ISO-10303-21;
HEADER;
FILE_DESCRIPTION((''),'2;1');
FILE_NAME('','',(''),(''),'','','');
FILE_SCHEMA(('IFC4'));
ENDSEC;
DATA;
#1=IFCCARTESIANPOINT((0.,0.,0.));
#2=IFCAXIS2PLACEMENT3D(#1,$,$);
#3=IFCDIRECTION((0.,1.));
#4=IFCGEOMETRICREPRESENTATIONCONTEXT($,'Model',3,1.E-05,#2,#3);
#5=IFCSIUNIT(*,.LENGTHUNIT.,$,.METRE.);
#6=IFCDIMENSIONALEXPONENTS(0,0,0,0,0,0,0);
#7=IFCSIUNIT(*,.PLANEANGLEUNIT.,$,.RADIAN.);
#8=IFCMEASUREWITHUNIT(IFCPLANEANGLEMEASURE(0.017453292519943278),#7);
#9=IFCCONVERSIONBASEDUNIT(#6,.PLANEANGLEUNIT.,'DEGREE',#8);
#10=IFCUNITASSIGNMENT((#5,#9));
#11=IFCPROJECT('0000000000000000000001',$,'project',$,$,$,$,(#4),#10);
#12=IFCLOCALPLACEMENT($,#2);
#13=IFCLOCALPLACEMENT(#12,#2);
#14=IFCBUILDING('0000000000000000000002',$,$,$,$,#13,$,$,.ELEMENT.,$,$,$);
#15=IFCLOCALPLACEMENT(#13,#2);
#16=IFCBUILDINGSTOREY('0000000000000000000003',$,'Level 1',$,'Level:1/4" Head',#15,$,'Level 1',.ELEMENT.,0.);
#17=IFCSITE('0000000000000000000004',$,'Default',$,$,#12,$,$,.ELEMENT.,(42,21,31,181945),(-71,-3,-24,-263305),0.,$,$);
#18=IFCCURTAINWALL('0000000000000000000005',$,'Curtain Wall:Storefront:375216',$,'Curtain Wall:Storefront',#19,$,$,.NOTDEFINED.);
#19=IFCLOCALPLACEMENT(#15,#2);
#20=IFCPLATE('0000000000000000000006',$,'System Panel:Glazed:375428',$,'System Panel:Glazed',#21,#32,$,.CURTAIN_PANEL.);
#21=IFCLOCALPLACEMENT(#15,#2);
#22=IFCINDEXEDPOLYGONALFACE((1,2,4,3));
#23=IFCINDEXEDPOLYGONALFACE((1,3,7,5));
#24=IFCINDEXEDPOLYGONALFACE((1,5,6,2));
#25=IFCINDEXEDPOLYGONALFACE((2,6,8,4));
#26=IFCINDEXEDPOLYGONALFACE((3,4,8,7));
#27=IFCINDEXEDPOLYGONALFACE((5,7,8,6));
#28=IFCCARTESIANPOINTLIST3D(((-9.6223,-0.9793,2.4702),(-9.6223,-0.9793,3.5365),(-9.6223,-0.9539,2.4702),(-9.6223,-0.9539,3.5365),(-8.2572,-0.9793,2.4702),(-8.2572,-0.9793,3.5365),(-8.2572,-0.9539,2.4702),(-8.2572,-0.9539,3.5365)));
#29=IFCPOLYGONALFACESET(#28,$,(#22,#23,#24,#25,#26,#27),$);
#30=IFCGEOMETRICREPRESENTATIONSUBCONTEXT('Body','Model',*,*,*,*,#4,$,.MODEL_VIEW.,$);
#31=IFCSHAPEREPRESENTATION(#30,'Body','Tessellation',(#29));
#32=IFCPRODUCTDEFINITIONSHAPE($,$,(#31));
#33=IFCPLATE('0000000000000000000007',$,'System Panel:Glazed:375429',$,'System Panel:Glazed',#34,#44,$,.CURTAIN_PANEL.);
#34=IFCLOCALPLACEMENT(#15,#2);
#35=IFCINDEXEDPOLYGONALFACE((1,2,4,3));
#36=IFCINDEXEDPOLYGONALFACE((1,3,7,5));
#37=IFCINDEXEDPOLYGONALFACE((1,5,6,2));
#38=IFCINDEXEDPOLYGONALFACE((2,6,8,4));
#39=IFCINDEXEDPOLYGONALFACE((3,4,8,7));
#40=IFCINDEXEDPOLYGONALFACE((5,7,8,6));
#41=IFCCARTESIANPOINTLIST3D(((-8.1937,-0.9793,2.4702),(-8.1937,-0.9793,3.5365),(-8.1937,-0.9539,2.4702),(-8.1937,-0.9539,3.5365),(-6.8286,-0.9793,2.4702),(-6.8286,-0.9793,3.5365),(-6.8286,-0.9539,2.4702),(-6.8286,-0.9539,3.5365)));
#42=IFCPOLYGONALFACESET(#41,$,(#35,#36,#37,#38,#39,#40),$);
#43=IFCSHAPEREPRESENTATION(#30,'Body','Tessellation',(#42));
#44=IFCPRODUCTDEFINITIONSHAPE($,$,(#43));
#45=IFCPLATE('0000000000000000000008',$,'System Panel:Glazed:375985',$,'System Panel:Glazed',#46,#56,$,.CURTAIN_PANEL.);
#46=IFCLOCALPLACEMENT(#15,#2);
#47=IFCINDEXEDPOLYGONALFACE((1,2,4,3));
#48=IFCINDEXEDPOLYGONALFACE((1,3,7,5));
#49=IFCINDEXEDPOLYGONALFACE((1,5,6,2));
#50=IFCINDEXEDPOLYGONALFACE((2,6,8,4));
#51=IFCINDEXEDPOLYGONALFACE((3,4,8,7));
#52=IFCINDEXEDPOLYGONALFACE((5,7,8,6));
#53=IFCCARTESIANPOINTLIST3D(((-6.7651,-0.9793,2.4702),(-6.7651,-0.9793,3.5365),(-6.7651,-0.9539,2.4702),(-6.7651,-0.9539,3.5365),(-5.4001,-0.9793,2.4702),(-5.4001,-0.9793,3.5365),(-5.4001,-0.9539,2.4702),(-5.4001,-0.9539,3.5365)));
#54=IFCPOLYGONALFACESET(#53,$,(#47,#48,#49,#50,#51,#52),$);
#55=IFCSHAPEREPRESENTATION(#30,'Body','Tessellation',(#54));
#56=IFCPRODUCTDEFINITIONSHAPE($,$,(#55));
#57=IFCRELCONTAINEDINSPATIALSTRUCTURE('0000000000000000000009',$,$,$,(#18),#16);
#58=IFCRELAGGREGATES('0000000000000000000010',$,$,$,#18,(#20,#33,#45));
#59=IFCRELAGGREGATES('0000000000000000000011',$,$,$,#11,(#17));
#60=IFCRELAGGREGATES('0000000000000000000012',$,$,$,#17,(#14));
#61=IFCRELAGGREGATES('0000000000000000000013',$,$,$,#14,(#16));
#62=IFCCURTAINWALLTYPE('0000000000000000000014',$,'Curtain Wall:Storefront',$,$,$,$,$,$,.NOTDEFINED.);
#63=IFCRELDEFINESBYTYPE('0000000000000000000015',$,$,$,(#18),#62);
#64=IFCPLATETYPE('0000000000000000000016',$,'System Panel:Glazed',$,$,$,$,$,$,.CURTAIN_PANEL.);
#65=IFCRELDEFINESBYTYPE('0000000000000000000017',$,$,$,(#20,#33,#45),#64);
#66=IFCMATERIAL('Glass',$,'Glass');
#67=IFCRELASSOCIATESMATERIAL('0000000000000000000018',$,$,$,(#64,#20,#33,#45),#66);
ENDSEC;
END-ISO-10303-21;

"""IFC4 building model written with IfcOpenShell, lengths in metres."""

from ifc_helpers import new_model, entity, si_unit, converted_unit, direction, frame, origin, place, context, subcontext, project, spatial, indexed_curve, outline, extrude, source, transform, mapped, material, type_object, type_shapes, element, aggregate, save


model = new_model("IFC4")

# Units and contexts
model_context = context("Model", 3, precision=1e-05, world=origin(), true_north=direction((0.0, 1.0)))
body_context = subcontext(model_context, "Body", "Model", "MODEL_VIEW")
ifc_project = project(units=[si_unit("LENGTHUNIT", "METRE"), converted_unit("PLANEANGLEUNIT", "DEGREE", entity("IfcPlaneAngleMeasure", 0.017453292519943278), si_unit("PLANEANGLEUNIT", "RADIAN"), dimensions=[0, 0, 0, 0, 0, 0, 0])], contexts=[model_context])

# Site, building, storey
site_placement = place(None, origin())
site = spatial("IfcSite", under=ifc_project, at=site_placement, Name="Default", CompositionType="ELEMENT", RefLatitude=(42, 21, 31, 181945), RefLongitude=(-71, -3, -24, -263305), RefElevation=0.0)
building_placement = place(site_placement, origin())
building = spatial("IfcBuilding", under=site, at=building_placement, CompositionType="ELEMENT")
storey_placement = place(building_placement, origin())
storey = spatial("IfcBuildingStorey", under=building, at=storey_placement, Name="Level 1", ObjectType="Level:1/4\" Head", LongName="Level 1", CompositionType="ELEMENT", Elevation=0.0)

# Curtain wall, plates
curtain_wall_type = type_object("IfcCurtainWallType", Name="Curtain Wall:Storefront", PredefinedType="NOTDEFINED")
curtain_wall_placement = place(storey_placement, origin())
curtain_wall = element("IfcCurtainWall", 1, at=curtain_wall_placement, inside=storey, type_object=curtain_wall_type, Name="Curtain Wall:Storefront:375216", ObjectType="Curtain Wall:Storefront", PredefinedType="NOTDEFINED")
ifc_material_1 = material(Name="Glass", Category="Glass")
plate_type_1 = type_object("IfcPlateType", Name="System Panel:Glazed", PredefinedType="CURTAIN_PANEL", material=ifc_material_1)
shared_shape_1 = source(origin(), body_context, "Body", "SweptSolid", [
    extrude(outline(indexed_curve([(-0.0127, -0.6825), (0.0127, -0.6825), (0.0127, 0.6825), (-0.0127, 0.6825), (-0.0127, -0.6825)], self_intersect=False)), frame((0.0, 0.0318, 0.0), z_axis=(0.0, 0.0, 1.0), x_axis=(0.0, 1.0, 0.0)), (0.0, 0.0, 1.0), 1.0663),
])
type_shapes(plate_type_1, [shared_shape_1])
plate_1_placement = place(curtain_wall_placement, frame((-8.9397, -0.9983, 2.4701)))
plate_1 = element("IfcPlate", 2, at=plate_1_placement, type_object=plate_type_1, material=ifc_material_1, Name="System Panel:Glazed:375428", ObjectType="System Panel:Glazed", PredefinedType="CURTAIN_PANEL", context=body_context, shape_type="MappedRepresentation", body=[
    mapped(shared_shape_1, transform((0.0, 0.0, 0.0), scale=1.0)),
])
plate_2_placement = place(curtain_wall_placement, frame((-7.5112, -0.9983, 2.4701)))
plate_2 = element("IfcPlate", 3, at=plate_2_placement, type_object=plate_type_1, material=ifc_material_1, Name="System Panel:Glazed:375429", ObjectType="System Panel:Glazed", PredefinedType="CURTAIN_PANEL", context=body_context, shape_type="MappedRepresentation", body=[
    mapped(shared_shape_1, transform((0.0, 0.0, 0.0), scale=1.0)),
])
plate_3_placement = place(curtain_wall_placement, frame((-6.0826, -0.9983, 2.4701)))
plate_3 = element("IfcPlate", 4, at=plate_3_placement, type_object=plate_type_1, material=ifc_material_1, Name="System Panel:Glazed:375985", ObjectType="System Panel:Glazed", PredefinedType="CURTAIN_PANEL", context=body_context, shape_type="MappedRepresentation", body=[
    mapped(shared_shape_1, transform((0.0, 0.0, 0.0), scale=1.0)),
])
aggregate(curtain_wall, [plate_1, plate_2, plate_3])

save(model, "model.ifc")
